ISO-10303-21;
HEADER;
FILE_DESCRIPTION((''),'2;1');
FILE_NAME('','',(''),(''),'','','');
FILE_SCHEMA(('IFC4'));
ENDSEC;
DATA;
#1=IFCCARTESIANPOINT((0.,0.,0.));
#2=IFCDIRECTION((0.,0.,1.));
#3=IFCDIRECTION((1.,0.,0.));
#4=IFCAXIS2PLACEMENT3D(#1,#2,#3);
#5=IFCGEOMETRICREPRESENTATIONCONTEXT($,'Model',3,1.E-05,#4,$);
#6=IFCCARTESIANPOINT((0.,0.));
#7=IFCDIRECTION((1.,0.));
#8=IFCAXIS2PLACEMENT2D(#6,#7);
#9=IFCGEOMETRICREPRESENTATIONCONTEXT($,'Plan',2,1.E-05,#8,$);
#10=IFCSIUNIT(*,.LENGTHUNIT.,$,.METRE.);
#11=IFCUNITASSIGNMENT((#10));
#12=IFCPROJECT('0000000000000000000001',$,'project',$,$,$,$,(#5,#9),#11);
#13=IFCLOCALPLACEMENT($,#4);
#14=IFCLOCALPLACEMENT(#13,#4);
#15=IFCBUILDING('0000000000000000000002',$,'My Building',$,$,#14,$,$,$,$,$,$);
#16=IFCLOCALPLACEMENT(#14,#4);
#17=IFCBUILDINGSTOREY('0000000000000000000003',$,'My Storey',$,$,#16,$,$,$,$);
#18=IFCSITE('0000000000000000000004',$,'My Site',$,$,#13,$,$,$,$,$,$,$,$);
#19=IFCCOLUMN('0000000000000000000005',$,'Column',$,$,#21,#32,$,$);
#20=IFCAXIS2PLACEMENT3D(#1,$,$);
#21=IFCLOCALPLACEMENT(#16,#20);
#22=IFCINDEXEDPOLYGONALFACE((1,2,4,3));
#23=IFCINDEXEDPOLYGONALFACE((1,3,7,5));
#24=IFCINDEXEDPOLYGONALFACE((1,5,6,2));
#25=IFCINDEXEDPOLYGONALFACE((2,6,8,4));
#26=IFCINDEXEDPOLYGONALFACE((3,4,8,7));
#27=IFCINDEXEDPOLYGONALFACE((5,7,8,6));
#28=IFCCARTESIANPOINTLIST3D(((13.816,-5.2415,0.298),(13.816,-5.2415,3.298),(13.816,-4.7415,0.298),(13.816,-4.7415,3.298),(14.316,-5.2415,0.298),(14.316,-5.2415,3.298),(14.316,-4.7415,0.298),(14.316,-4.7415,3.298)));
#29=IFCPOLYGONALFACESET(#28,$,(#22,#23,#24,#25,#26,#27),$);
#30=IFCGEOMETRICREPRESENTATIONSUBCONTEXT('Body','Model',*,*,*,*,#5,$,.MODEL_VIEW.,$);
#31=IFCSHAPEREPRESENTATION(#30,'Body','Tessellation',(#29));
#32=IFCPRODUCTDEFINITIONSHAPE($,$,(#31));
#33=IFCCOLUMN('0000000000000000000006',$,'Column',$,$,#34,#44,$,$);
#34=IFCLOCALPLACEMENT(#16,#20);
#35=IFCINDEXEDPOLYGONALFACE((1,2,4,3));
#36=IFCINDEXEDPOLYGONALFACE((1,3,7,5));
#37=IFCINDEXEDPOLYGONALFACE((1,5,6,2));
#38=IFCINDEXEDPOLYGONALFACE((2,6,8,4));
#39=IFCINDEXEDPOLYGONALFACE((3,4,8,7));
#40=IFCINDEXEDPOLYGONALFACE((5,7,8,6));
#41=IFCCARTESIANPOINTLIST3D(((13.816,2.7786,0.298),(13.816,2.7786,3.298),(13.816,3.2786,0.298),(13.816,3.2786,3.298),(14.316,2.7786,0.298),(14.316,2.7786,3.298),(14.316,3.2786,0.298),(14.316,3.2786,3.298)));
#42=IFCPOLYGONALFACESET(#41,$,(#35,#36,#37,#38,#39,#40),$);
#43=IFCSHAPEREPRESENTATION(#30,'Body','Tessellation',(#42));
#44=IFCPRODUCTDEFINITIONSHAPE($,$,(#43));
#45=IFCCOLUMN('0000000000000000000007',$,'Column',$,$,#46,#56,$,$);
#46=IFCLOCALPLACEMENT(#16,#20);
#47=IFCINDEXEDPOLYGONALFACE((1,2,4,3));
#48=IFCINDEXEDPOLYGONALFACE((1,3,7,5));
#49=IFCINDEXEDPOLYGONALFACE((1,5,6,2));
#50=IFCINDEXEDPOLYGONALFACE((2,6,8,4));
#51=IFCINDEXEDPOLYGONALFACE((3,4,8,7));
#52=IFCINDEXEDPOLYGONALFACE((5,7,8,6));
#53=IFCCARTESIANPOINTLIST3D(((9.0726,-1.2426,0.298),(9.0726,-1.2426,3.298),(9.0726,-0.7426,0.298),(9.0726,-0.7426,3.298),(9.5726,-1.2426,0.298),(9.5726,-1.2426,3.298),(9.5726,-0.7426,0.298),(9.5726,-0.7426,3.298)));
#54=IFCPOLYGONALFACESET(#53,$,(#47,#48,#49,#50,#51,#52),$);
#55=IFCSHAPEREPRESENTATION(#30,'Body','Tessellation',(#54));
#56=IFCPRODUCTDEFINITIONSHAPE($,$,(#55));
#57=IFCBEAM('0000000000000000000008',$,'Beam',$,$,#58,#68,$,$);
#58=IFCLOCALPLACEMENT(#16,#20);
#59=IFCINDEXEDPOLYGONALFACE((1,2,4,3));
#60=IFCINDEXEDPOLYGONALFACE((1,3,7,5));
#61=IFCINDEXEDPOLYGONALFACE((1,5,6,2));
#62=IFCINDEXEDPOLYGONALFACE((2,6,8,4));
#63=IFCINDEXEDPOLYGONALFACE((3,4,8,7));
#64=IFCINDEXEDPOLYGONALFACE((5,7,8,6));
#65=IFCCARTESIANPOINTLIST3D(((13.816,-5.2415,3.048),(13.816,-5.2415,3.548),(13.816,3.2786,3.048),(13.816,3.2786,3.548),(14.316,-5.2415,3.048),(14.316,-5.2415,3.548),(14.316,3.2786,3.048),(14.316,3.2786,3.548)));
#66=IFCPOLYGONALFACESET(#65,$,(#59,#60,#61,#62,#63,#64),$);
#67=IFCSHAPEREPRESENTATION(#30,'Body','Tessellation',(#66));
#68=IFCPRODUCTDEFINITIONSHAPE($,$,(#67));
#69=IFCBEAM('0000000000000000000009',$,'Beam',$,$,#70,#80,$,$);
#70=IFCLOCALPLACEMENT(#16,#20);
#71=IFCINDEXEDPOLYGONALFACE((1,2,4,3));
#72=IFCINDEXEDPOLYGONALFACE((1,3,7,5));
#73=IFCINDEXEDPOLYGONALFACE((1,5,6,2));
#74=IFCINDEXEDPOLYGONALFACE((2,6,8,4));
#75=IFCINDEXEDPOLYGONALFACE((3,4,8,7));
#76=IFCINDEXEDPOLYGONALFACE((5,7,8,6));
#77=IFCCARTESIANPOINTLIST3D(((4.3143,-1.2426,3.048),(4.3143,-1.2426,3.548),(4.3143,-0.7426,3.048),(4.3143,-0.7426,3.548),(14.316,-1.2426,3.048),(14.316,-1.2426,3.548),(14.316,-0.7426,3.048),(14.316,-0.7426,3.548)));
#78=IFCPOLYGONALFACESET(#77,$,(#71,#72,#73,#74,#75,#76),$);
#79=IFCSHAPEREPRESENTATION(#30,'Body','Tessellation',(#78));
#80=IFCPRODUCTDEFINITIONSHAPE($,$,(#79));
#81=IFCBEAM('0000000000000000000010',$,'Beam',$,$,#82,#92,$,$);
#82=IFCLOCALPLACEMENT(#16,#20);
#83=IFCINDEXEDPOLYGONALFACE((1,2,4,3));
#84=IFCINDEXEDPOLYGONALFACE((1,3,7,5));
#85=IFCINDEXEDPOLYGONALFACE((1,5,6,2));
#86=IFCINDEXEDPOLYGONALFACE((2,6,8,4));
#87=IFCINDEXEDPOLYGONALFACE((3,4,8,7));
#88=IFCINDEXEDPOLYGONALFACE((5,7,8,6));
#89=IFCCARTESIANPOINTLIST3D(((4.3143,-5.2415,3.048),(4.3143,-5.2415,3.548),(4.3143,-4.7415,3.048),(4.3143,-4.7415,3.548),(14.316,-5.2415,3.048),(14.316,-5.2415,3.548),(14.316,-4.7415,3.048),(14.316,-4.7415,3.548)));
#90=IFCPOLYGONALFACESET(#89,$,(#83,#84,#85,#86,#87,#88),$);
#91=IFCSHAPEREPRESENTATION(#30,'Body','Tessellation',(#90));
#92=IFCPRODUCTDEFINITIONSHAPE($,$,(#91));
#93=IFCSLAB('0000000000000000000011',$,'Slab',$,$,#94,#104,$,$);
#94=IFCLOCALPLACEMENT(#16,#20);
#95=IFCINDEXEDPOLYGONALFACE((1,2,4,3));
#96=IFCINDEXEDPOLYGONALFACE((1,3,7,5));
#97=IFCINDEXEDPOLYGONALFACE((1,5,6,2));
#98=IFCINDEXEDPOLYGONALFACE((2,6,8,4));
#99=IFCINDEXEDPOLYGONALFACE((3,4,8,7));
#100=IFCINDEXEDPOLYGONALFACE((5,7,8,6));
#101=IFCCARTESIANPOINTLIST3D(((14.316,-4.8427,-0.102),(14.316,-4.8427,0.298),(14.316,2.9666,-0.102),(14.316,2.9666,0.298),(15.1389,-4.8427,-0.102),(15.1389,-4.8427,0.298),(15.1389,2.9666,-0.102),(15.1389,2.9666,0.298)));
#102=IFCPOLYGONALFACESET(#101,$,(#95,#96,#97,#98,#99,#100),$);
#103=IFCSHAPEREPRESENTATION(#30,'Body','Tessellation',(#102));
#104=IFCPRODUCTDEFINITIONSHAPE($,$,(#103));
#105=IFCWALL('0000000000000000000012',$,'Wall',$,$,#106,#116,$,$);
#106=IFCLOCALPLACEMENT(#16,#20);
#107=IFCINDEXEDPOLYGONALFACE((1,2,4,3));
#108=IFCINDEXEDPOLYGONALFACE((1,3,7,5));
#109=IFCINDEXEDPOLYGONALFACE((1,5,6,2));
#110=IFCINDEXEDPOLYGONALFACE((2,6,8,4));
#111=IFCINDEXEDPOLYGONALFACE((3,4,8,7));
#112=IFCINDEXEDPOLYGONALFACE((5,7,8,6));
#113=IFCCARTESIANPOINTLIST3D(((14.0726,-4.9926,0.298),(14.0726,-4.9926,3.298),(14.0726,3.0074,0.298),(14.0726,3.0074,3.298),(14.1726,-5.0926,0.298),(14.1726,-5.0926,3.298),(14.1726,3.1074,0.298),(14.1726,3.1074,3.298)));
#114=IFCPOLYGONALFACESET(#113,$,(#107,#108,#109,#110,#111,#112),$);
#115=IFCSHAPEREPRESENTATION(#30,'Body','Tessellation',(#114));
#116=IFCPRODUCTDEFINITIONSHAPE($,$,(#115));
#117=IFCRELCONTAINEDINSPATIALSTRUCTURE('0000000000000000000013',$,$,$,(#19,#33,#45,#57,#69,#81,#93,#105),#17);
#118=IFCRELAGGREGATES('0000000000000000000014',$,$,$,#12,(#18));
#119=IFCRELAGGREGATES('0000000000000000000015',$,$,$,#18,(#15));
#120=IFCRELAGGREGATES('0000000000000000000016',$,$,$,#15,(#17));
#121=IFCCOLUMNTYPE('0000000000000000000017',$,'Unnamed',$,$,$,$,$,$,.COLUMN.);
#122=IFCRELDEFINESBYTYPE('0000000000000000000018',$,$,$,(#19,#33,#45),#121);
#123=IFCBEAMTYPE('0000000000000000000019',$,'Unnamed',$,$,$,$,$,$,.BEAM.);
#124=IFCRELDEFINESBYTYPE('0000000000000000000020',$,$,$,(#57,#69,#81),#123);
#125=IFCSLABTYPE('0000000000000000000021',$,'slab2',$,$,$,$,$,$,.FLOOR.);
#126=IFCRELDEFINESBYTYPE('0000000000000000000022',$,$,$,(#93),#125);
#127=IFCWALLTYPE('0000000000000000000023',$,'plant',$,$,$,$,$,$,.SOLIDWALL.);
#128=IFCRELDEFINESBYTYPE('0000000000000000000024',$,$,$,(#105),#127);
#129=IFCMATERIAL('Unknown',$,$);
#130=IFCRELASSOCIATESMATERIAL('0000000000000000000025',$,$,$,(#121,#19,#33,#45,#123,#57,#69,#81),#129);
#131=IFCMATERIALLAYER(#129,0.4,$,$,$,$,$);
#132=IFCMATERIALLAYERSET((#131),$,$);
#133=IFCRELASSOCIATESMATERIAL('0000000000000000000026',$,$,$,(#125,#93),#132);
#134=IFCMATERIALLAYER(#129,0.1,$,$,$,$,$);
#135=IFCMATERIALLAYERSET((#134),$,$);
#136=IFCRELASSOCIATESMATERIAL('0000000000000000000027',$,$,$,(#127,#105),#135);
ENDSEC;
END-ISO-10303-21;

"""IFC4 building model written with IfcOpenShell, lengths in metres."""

from ifc_helpers import new_model, si_unit, frame, origin_with_axes, origin_2d_with_axis, place, context, subcontext, project, spatial, line, indexed_curve, outline, extrude, material, layer, layer_set, layer_usage, material_profile, profile_set, profile_usage, type_object, element, save


model = new_model("IFC4")

# Units and contexts
model_context = context("Model", 3, precision=1e-05, world=origin_with_axes())
plan_context = context("Plan", 2, precision=1e-05, world=origin_2d_with_axis())
body_context_1 = subcontext(model_context, "Body", "Model", "MODEL_VIEW")
ifc_project = project(units=[si_unit("LENGTHUNIT", "METRE")], contexts=[model_context, plan_context])

# Site, building, storey
site_placement = place(None, origin_with_axes())
site = spatial("IfcSite", under=ifc_project, at=site_placement, Name="My Site")
building_placement = place(site_placement, origin_with_axes())
building = spatial("IfcBuilding", under=site, at=building_placement, Name="My Building")
storey_placement = place(building_placement, origin_with_axes())
storey = spatial("IfcBuildingStorey", under=building, at=storey_placement, Name="My Storey")

# Columns
ifc_material = material(Name="Unknown")
ifc_material_profile_1 = material_profile(ifc_material, outline(indexed_curve([(-0.25, 0.25), (0.25, 0.25), (0.25, -0.25), (-0.25, -0.25), (-0.25, 0.25)])))
ifc_profile_set_1 = profile_set([ifc_material_profile_1])
ifc_profile_usage_1 = profile_usage(ifc_profile_set_1, cardinal=5)
column_type = type_object("IfcColumnType", Name="Unnamed", PredefinedType="COLUMN", material=ifc_profile_set_1)
column_1_placement = place(storey_placement, frame((14.066, -4.9915, 0.298), z_axis=(0.0, 0.0, 1.0), x_axis=(1.0, 0.0, 0.0)))
element("IfcColumn", 1, at=column_1_placement, inside=storey, type_object=column_type, material=ifc_profile_usage_1, Name="Column", context=body_context_1, shape_type="SweptSolid", body=[
    extrude(outline(indexed_curve([(-0.25, 0.25), (0.25, 0.25), (0.25, -0.25), (-0.25, -0.25), (-0.25, 0.25)])), origin_with_axes(), (0.0, 0.0, 1.0), 3.0),
])
ifc_profile_usage_2 = profile_usage(ifc_profile_set_1, cardinal=5)
column_2_placement = place(storey_placement, frame((14.066, 3.0286, 0.298), z_axis=(0.0, 0.0, 1.0), x_axis=(1.0, 0.0, 0.0)))
element("IfcColumn", 2, at=column_2_placement, inside=storey, type_object=column_type, material=ifc_profile_usage_2, Name="Column", context=body_context_1, shape_type="SweptSolid", body=[
    extrude(outline(indexed_curve([(-0.25, 0.25), (0.25, 0.25), (0.25, -0.25), (-0.25, -0.25), (-0.25, 0.25)])), origin_with_axes(), (0.0, 0.0, 1.0), 3.0),
])
ifc_profile_usage_3 = profile_usage(ifc_profile_set_1, cardinal=5)
column_3_placement = place(storey_placement, frame((9.3226, -0.9926, 0.298), z_axis=(0.0, 0.0, 1.0), x_axis=(1.0, 0.0, 0.0)))
element("IfcColumn", 3, at=column_3_placement, inside=storey, type_object=column_type, material=ifc_profile_usage_3, Name="Column", context=body_context_1, shape_type="SweptSolid", body=[
    extrude(outline(indexed_curve([(-0.25, 0.25), (0.25, 0.25), (0.25, -0.25), (-0.25, -0.25), (-0.25, 0.25)])), origin_with_axes(), (0.0, 0.0, 1.0), 3.0),
])

# Beams
ifc_material_profile_2 = material_profile(ifc_material, outline(indexed_curve([(-0.25, 0.25), (0.25, 0.25), (0.25, -0.25), (-0.25, -0.25), (-0.25, 0.25)])))
ifc_profile_set_2 = profile_set([ifc_material_profile_2])
ifc_profile_usage_4 = profile_usage(ifc_profile_set_2, cardinal=5)
beam_type = type_object("IfcBeamType", Name="Unnamed", PredefinedType="BEAM", material=ifc_profile_set_2)
beam_1_placement = place(storey_placement, frame((14.066, 3.2786, 3.298), z_axis=(0.0, -1.0, 0.0), x_axis=(1.0, 0.0, 0.0)))
element("IfcBeam", 4, at=beam_1_placement, inside=storey, type_object=beam_type, material=ifc_profile_usage_4, Name="Beam", context=body_context_1, shape_type="SweptSolid", body=[
    extrude(outline(indexed_curve([(-0.25, 0.25), (0.25, 0.25), (0.25, -0.25), (-0.25, -0.25), (-0.25, 0.25)])), origin_with_axes(), (0.0, 0.0, 1.0), 8.5201),
])
ifc_profile_usage_5 = profile_usage(ifc_profile_set_2, cardinal=5)
beam_2_placement = place(storey_placement, frame((14.316, -0.9926, 3.298), z_axis=(-1.0, 0.0, 0.0), x_axis=(0.0, -1.0, 0.0)))
element("IfcBeam", 5, at=beam_2_placement, inside=storey, type_object=beam_type, material=ifc_profile_usage_5, Name="Beam", context=body_context_1, shape_type="SweptSolid", body=[
    extrude(outline(indexed_curve([(-0.25, 0.25), (0.25, 0.25), (0.25, -0.25), (-0.25, -0.25), (-0.25, 0.25)])), origin_with_axes(), (0.0, 0.0, 1.0), 10.0017),
])
ifc_profile_usage_6 = profile_usage(ifc_profile_set_2, cardinal=5)
beam_3_placement = place(storey_placement, frame((14.316, -4.9915, 3.298), z_axis=(-1.0, 0.0, 0.0), x_axis=(0.0, -1.0, 0.0)))
element("IfcBeam", 6, at=beam_3_placement, inside=storey, type_object=beam_type, material=ifc_profile_usage_6, Name="Beam", context=body_context_1, shape_type="SweptSolid", body=[
    extrude(outline(indexed_curve([(-0.25, 0.25), (0.25, 0.25), (0.25, -0.25), (-0.25, -0.25), (-0.25, 0.25)])), origin_with_axes(), (0.0, 0.0, 1.0), 10.0017),
])

# Slab
ifc_layer_1 = layer(ifc_material, 0.4)
ifc_layer_set_1 = layer_set([ifc_layer_1])
ifc_layer_usage_1 = layer_usage(ifc_layer_set_1, "AXIS3", "POSITIVE", -0.4)
slab_type = type_object("IfcSlabType", Name="slab2", PredefinedType="FLOOR", material=ifc_layer_set_1)
slab_placement = place(storey_placement, frame((14.316, -4.8427, 0.298), z_axis=(0.0, 0.0, 1.0), x_axis=(1.0, 0.0, 0.0)))
element("IfcSlab", 7, at=slab_placement, inside=storey, type_object=slab_type, material=ifc_layer_usage_1, Name="Slab", context=body_context_1, shape_type="SweptSolid", body=[
    extrude(outline(indexed_curve([(0.0, 0.0), (0.8229, 0.0), (0.8229, 7.8093), (0.0, 7.8093), (0.0, 0.0)])), frame((0.0, 0.0, -0.4), z_axis=(0.0, 0.0, 1.0), x_axis=(1.0, 0.0, 0.0)), (0.0, 0.0, 1.0), 0.4),
])

# Wall
ifc_layer_2 = layer(ifc_material, 0.1)
ifc_layer_set_2 = layer_set([ifc_layer_2])
ifc_layer_usage_2 = layer_usage(ifc_layer_set_2, "AXIS2", "POSITIVE", 0.0)
wall_type = type_object("IfcWallType", Name="plant", PredefinedType="SOLIDWALL", material=ifc_layer_set_2)
wall_1_placement = place(storey_placement, frame((14.0726, 3.0074, 0.298), z_axis=(0.0, 0.0, 1.0), x_axis=(0.0, -1.0, 0.0)))
element("IfcWall", 8, at=wall_1_placement, inside=storey, type_object=wall_type, material=ifc_layer_usage_2, Name="Wall", context=body_context_1, shape_type="SweptSolid", body=[
    extrude(outline(indexed_curve([(0.0, 0.0), (-0.1, 0.1), (8.1, 0.1), (8.0, 0.0)], segments=[line(1, 2, 3, 4, 1)])), origin_with_axes(), (0.0, 0.0, 1.0), 3.0),
])

save(model, "model.ifc")
